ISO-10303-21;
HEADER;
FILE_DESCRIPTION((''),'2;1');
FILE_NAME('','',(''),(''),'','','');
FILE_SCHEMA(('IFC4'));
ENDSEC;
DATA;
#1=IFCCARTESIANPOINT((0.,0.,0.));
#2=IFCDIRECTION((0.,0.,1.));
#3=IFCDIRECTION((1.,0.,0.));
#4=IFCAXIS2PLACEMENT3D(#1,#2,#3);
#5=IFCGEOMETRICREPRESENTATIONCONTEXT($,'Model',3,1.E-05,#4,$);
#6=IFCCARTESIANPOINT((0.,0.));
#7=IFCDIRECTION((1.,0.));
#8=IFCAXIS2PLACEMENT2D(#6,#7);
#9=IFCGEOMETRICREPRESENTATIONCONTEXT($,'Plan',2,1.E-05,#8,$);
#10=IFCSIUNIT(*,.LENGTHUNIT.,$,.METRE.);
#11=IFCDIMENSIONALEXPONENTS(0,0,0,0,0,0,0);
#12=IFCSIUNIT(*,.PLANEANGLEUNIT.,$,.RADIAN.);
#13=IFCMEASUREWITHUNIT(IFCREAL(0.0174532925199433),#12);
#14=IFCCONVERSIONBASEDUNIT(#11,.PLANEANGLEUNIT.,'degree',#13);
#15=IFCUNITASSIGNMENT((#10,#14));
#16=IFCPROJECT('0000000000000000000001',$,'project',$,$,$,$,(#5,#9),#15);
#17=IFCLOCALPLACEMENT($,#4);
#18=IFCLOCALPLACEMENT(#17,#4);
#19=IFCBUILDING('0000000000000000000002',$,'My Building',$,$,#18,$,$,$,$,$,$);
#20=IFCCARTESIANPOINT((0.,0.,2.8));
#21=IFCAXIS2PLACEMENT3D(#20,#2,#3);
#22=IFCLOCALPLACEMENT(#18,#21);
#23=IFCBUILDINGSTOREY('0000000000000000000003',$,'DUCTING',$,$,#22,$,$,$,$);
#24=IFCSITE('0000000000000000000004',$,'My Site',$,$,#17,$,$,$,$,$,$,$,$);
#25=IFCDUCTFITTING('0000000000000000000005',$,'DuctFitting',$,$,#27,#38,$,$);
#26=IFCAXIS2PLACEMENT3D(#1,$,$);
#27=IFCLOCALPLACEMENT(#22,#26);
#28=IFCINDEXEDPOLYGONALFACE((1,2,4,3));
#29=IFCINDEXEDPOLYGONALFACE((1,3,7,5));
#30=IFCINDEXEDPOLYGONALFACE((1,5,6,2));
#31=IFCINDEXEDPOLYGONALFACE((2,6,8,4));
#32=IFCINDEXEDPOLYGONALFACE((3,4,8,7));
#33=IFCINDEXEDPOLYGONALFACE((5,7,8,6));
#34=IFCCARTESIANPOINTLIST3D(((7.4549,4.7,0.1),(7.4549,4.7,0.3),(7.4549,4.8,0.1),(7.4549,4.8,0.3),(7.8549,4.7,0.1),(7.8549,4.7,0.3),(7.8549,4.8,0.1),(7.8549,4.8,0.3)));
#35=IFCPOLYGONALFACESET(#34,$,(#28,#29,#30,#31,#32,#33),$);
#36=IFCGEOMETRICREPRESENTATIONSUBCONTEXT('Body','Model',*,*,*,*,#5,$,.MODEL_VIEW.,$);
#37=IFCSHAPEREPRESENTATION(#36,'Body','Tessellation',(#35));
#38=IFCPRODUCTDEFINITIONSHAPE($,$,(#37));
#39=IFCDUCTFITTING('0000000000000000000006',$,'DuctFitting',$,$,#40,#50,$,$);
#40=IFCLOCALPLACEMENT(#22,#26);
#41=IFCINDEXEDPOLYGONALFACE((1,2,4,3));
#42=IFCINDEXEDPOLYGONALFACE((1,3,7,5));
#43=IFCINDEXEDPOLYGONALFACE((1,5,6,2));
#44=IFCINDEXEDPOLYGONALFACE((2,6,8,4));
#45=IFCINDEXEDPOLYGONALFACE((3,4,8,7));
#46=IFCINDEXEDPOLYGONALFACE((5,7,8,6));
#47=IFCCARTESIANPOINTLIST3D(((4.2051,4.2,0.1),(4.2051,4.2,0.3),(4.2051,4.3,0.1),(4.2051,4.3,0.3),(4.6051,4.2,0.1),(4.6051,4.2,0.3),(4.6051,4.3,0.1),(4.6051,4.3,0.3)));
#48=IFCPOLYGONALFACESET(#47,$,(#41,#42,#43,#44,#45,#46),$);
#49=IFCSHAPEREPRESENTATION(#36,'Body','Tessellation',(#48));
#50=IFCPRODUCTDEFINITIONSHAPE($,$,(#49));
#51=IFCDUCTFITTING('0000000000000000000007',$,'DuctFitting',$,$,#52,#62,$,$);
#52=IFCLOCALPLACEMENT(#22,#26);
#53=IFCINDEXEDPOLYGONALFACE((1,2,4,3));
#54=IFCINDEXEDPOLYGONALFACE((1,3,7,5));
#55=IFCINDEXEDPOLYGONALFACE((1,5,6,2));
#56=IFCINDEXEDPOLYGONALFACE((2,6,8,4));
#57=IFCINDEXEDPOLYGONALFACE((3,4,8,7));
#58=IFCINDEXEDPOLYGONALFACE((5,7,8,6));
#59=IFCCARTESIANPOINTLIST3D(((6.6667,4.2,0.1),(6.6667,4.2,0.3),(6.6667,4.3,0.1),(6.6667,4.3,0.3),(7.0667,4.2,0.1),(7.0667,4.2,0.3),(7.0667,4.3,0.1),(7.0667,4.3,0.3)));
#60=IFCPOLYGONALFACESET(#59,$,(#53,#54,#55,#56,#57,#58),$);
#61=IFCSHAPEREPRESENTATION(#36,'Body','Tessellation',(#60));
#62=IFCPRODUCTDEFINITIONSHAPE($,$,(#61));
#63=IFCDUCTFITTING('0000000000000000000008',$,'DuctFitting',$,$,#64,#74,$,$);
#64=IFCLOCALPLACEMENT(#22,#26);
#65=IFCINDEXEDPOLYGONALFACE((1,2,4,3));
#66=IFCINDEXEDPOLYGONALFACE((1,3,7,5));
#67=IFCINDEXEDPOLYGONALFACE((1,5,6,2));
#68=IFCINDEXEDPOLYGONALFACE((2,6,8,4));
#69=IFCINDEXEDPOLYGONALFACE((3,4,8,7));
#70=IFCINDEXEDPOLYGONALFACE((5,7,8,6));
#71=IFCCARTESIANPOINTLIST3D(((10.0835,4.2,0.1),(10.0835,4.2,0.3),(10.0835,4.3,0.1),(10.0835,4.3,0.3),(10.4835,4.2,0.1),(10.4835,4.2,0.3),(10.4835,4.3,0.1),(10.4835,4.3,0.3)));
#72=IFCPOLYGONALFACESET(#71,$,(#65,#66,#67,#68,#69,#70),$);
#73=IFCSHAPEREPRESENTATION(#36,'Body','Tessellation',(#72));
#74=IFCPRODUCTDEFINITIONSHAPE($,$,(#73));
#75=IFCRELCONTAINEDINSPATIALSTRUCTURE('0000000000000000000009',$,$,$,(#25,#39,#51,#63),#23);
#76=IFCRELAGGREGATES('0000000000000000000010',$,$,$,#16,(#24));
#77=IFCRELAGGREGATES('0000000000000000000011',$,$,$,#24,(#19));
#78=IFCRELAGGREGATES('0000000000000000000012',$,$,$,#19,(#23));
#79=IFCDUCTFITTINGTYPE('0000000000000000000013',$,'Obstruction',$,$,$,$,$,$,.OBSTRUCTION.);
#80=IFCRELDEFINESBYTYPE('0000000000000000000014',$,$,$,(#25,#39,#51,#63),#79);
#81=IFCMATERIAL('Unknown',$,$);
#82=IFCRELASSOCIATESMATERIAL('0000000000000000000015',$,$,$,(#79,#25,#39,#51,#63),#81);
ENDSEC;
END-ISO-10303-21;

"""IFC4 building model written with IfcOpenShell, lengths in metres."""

from ifc_helpers import new_model, entity, si_unit, converted_unit, frame, origin_with_axes, origin_2d_with_axis, place, context, subcontext, project, spatial, rectangle, extrude, material, material_profile, profile_set, profile_usage, type_object, element, save


model = new_model("IFC4")

# Units and contexts
model_context = context("Model", 3, precision=1e-05, world=origin_with_axes())
plan_context = context("Plan", 2, precision=1e-05, world=origin_2d_with_axis())
body_context = subcontext(model_context, "Body", "Model", "MODEL_VIEW")
ifc_project = project(units=[si_unit("LENGTHUNIT", "METRE"), converted_unit("PLANEANGLEUNIT", "degree", entity("IfcReal", 0.0174532925199433), si_unit("PLANEANGLEUNIT", "RADIAN"), dimensions=[0, 0, 0, 0, 0, 0, 0])], contexts=[model_context, plan_context])

# Site, building, storey
site_placement = place(None, origin_with_axes())
site = spatial("IfcSite", under=ifc_project, at=site_placement, Name="My Site")
building_placement = place(site_placement, origin_with_axes())
building = spatial("IfcBuilding", under=site, at=building_placement, Name="My Building")
storey_placement = place(building_placement, frame((0.0, 0.0, 2.8), z_axis=(0.0, 0.0, 1.0), x_axis=(1.0, 0.0, 0.0)))
storey = spatial("IfcBuildingStorey", under=building, at=storey_placement, Name="DUCTING")

# Shared definitions
ifc_material = material(Name="Unknown")

# Duct fittings
ifc_material_profile_1 = material_profile(ifc_material, rectangle(XDim=0.4, YDim=0.2))
ifc_profile_set_1 = profile_set([ifc_material_profile_1])
duct_fitting_type_1 = type_object("IfcDuctFittingType", Name="Obstruction", PredefinedType="OBSTRUCTION", material=ifc_profile_set_1)
ifc_profile_usage_1 = profile_usage(ifc_profile_set_1, cardinal=5)
duct_fitting_1_placement = place(storey_placement, frame((7.6549, 4.7, 0.2), z_axis=(0.0, 1.0, 0.0), x_axis=(-1.0, 0.0, 0.0)))
element("IfcDuctFitting", 1, at=duct_fitting_1_placement, inside=storey, type_object=duct_fitting_type_1, material=ifc_profile_usage_1, Name="DuctFitting", context=body_context, shape_type="SweptSolid", body=[
    extrude(rectangle(XDim=0.4, YDim=0.2), origin_with_axes(), (0.0, 0.0, 1.0), 0.1),
])
ifc_profile_usage_2 = profile_usage(ifc_profile_set_1, cardinal=5)
duct_fitting_2_placement = place(storey_placement, frame((4.4051, 4.3, 0.2), z_axis=(0.0, -1.0, 0.0), x_axis=(1.0, 0.0, 0.0)))
element("IfcDuctFitting", 2, at=duct_fitting_2_placement, inside=storey, type_object=duct_fitting_type_1, material=ifc_profile_usage_2, Name="DuctFitting", context=body_context, shape_type="SweptSolid", body=[
    extrude(rectangle(XDim=0.4, YDim=0.2), origin_with_axes(), (0.0, 0.0, 1.0), 0.1),
])
ifc_profile_usage_3 = profile_usage(ifc_profile_set_1, cardinal=5)
duct_fitting_3_placement = place(storey_placement, frame((6.8667, 4.3, 0.2), z_axis=(0.0, -1.0, 0.0), x_axis=(1.0, 0.0, 0.0)))
element("IfcDuctFitting", 3, at=duct_fitting_3_placement, inside=storey, type_object=duct_fitting_type_1, material=ifc_profile_usage_3, Name="DuctFitting", context=body_context, shape_type="SweptSolid", body=[
    extrude(rectangle(XDim=0.4, YDim=0.2), origin_with_axes(), (0.0, 0.0, 1.0), 0.1),
])
ifc_profile_usage_4 = profile_usage(ifc_profile_set_1, cardinal=5)
duct_fitting_4_placement = place(storey_placement, frame((10.2835, 4.3, 0.2), z_axis=(0.0, -1.0, 0.0), x_axis=(1.0, 0.0, 0.0)))
element("IfcDuctFitting", 4, at=duct_fitting_4_placement, inside=storey, type_object=duct_fitting_type_1, material=ifc_profile_usage_4, Name="DuctFitting", context=body_context, shape_type="SweptSolid", body=[
    extrude(rectangle(XDim=0.4, YDim=0.2), origin_with_axes(), (0.0, 0.0, 1.0), 0.1),
])

save(model, "model.ifc")
